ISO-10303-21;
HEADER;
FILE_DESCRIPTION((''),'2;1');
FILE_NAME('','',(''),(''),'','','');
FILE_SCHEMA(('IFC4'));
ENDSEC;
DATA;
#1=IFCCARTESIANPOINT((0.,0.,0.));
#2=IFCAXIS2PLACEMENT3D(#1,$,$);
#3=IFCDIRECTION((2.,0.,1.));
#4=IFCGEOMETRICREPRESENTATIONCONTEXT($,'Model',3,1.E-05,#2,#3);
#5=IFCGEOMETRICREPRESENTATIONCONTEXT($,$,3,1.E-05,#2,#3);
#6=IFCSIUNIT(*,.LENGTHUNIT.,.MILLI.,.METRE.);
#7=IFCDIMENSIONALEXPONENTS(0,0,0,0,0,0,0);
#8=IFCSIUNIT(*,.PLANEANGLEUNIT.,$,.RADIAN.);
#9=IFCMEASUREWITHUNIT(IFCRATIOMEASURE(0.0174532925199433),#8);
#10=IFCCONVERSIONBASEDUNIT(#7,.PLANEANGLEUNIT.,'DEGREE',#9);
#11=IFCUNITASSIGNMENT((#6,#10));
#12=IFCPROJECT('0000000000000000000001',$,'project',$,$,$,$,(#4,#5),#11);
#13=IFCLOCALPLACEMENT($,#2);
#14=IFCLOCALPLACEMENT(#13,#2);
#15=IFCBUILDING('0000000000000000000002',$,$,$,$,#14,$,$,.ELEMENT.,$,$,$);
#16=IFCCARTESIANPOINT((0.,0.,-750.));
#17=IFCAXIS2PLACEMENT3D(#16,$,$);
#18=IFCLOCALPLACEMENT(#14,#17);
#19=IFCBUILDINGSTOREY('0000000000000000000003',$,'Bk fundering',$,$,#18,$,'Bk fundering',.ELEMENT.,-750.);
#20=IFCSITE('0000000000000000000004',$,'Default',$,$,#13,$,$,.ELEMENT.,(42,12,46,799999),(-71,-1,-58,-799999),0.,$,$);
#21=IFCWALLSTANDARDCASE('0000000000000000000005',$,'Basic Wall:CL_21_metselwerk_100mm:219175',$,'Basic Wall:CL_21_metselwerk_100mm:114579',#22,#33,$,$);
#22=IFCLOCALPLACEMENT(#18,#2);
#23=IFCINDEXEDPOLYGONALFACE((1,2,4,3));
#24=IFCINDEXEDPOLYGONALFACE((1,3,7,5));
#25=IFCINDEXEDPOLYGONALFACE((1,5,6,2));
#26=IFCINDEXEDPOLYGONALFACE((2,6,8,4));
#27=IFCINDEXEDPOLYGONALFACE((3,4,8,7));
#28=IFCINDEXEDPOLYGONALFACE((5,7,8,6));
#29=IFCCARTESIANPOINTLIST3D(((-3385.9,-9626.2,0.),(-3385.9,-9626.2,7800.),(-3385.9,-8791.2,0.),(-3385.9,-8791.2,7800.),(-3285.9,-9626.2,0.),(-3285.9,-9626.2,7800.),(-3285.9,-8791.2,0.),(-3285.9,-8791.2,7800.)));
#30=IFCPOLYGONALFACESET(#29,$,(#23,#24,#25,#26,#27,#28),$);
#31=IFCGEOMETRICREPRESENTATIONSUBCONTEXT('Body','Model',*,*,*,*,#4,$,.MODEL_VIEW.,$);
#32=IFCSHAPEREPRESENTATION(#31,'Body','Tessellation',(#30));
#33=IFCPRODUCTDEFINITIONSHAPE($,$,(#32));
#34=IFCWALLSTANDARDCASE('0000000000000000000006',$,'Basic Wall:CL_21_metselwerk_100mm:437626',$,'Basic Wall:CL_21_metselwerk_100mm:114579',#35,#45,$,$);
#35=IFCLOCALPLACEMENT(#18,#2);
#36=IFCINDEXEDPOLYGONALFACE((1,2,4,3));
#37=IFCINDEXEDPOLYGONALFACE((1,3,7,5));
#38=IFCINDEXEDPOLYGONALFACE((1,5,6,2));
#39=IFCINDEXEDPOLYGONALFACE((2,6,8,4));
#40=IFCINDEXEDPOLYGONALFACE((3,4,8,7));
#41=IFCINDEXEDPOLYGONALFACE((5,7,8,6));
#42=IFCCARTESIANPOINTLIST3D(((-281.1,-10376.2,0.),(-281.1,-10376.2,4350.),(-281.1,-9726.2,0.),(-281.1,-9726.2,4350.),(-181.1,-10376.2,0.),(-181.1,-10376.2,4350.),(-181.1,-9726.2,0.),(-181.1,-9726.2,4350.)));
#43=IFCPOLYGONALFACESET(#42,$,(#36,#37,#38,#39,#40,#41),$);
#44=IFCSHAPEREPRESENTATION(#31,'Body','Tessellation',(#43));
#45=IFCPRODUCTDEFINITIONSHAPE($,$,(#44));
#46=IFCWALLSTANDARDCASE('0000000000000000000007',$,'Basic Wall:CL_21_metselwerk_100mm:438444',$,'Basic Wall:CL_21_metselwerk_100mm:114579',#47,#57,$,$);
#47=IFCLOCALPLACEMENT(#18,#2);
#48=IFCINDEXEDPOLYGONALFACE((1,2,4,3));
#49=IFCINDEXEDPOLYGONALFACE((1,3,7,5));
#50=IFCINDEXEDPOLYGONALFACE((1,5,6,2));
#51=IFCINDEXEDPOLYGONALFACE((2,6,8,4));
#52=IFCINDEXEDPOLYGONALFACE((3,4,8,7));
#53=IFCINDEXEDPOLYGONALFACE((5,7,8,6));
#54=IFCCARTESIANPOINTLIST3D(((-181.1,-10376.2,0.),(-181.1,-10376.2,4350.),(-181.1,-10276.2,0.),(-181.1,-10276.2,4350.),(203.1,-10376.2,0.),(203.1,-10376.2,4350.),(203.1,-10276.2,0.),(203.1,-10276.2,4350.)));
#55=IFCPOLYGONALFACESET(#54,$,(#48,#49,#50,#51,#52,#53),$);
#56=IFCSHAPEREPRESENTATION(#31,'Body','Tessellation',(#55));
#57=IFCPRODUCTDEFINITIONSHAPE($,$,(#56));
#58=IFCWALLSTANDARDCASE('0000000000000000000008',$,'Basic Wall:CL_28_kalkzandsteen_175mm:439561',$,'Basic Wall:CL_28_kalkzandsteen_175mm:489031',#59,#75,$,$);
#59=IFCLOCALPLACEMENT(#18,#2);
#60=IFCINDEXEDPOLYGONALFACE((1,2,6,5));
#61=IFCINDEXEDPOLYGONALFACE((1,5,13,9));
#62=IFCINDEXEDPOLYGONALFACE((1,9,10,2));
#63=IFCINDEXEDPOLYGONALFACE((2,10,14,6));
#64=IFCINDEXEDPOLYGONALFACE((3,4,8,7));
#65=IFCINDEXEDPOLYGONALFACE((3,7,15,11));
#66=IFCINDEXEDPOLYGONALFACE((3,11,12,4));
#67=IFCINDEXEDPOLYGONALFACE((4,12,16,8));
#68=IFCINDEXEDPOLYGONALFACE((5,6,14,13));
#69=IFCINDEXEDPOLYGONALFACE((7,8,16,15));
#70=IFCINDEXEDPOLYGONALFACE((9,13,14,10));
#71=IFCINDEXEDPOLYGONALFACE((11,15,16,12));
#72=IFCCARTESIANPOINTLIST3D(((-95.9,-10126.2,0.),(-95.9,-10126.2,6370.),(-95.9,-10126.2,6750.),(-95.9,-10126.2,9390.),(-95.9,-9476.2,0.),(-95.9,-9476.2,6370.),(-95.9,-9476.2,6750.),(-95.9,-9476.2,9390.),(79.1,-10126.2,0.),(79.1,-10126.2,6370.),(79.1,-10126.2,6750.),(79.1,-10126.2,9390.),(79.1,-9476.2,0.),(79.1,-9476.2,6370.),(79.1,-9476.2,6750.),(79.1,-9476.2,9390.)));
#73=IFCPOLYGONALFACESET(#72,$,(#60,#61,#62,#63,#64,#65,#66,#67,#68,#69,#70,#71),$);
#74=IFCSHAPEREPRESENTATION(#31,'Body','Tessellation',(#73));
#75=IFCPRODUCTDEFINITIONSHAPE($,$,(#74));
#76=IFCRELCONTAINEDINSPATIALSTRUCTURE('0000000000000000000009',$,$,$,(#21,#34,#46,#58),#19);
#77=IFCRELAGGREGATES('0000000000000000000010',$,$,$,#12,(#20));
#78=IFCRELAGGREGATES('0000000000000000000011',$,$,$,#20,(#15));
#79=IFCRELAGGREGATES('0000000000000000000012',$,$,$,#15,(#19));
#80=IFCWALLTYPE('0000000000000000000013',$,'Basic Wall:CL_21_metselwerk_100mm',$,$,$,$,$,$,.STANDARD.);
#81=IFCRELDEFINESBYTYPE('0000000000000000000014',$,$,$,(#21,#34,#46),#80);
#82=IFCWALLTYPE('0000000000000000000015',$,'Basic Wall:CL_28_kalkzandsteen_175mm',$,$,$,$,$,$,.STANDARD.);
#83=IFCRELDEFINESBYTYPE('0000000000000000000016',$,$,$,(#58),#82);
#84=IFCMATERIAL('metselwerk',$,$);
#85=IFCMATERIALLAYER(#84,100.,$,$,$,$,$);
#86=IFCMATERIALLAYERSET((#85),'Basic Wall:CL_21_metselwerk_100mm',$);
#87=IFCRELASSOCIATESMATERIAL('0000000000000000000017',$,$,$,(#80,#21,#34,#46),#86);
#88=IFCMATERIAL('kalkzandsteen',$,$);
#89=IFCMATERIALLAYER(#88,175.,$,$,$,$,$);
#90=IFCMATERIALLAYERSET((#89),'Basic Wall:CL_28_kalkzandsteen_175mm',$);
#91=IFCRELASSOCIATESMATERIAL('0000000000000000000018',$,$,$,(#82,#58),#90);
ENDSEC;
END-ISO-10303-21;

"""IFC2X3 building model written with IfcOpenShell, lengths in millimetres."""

from ifc_helpers import new_model, entity, si_unit, converted_unit, direction, frame, frame_2d, origin, place, context, subcontext, project, spatial, rectangle, extrude, material, layer, layer_set, layer_usage, type_object, element, save


model = new_model("IFC2X3")

# Units and contexts
model_context = context("Model", 3, precision=1e-05, world=origin(), true_north=direction((2.0, 0.0, 1.0)))
context_of_model = context(None, 3, precision=1e-05, world=origin(), true_north=direction((2.0, 0.0, 1.0)))
body_context = subcontext(model_context, "Body", "Model", "MODEL_VIEW")
ifc_project = project(units=[si_unit("LENGTHUNIT", "METRE", prefix="MILLI"), converted_unit("PLANEANGLEUNIT", "DEGREE", entity("IfcRatioMeasure", 0.0174532925199433), si_unit("PLANEANGLEUNIT", "RADIAN"), dimensions=[0, 0, 0, 0, 0, 0, 0])], contexts=[model_context, context_of_model])

# Site, building, storey
site_placement = place(None, origin())
site = spatial("IfcSite", under=ifc_project, at=site_placement, Name="Default", CompositionType="ELEMENT", RefLatitude=(42, 12, 46, 799999), RefLongitude=(-71, -1, -58, -799999), RefElevation=0.0)
building_placement = place(site_placement, origin())
building = spatial("IfcBuilding", under=site, at=building_placement, CompositionType="ELEMENT")
storey_placement = place(building_placement, frame((0.0, 0.0, -750.0)))
storey = spatial("IfcBuildingStorey", under=building, at=storey_placement, Name="Bk fundering", LongName="Bk fundering", CompositionType="ELEMENT", Elevation=-750.0)

# Shared definitions
ifc_material_1 = material(Name="kalkzandsteen")

# Walls
ifc_material_2 = material(Name="metselwerk")
ifc_layer_1 = layer(ifc_material_2, 100.0)
ifc_layer_set_1 = layer_set([ifc_layer_1], Name="Basic Wall:CL_21_metselwerk_100mm")
wall_type_1 = type_object("IfcWallType", Name="Basic Wall:CL_21_metselwerk_100mm", PredefinedType="STANDARD", material=ifc_layer_set_1)
ifc_layer_usage_1 = layer_usage(ifc_layer_set_1, "AXIS2", "NEGATIVE", 50.0)
wall_1_placement = place(storey_placement, frame((-3335.9, -8791.2, 0.0), z_axis=(0.0, 0.0, 1.0), x_axis=(0.0, -1.0, 0.0)))
element("IfcWallStandardCase", 1, at=wall_1_placement, inside=storey, type_object=wall_type_1, material=ifc_layer_usage_1, Name="Basic Wall:CL_21_metselwerk_100mm:219175", ObjectType="Basic Wall:CL_21_metselwerk_100mm:114579", context=body_context, shape_type="SweptSolid", body=[
    extrude(rectangle(XDim=835.0, YDim=100.0, at=frame_2d((417.5, 0.0), x_axis=(-1.0, 0.0))), origin(), (0.0, 0.0, 1.0), 7800.0),
])
ifc_layer_usage_2 = layer_usage(ifc_layer_set_1, "AXIS2", "NEGATIVE", 50.0)
wall_2_placement = place(storey_placement, frame((-231.1, -9726.2, 0.0), z_axis=(0.0, 0.0, 1.0), x_axis=(0.0, -1.0, 0.0)))
element("IfcWallStandardCase", 2, at=wall_2_placement, inside=storey, type_object=wall_type_1, material=ifc_layer_usage_2, Name="Basic Wall:CL_21_metselwerk_100mm:437626", ObjectType="Basic Wall:CL_21_metselwerk_100mm:114579", context=body_context, shape_type="SweptSolid", body=[
    extrude(rectangle(XDim=650.0, YDim=100.0, at=frame_2d((325.0, 0.0), x_axis=(-1.0, 0.0))), origin(), (0.0, 0.0, 1.0), 4350.0),
])
ifc_layer_usage_3 = layer_usage(ifc_layer_set_1, "AXIS2", "NEGATIVE", 50.0)
wall_3_placement = place(storey_placement, frame((-181.1, -10326.2, 0.0)))
element("IfcWallStandardCase", 3, at=wall_3_placement, inside=storey, type_object=wall_type_1, material=ifc_layer_usage_3, Name="Basic Wall:CL_21_metselwerk_100mm:438444", ObjectType="Basic Wall:CL_21_metselwerk_100mm:114579", context=body_context, shape_type="SweptSolid", body=[
    extrude(rectangle(XDim=384.2, YDim=100.0, at=frame_2d((192.1, 0.0), x_axis=(-1.0, 0.0))), origin(), (0.0, 0.0, 1.0), 4350.0),
])

# Wall, opening
ifc_layer_2 = layer(ifc_material_1, 175.0)
ifc_layer_set_2 = layer_set([ifc_layer_2], Name="Basic Wall:CL_28_kalkzandsteen_175mm")
ifc_layer_usage_4 = layer_usage(ifc_layer_set_2, "AXIS2", "NEGATIVE", 87.5)
wall_type_2 = type_object("IfcWallType", Name="Basic Wall:CL_28_kalkzandsteen_175mm", PredefinedType="STANDARD", material=ifc_layer_set_2)
wall_4_placement = place(storey_placement, frame((-8.4, -9476.2, 0.0), z_axis=(0.0, 0.0, 1.0), x_axis=(0.0, -1.0, 0.0)))
wall_4 = element("IfcWallStandardCase", 4, at=wall_4_placement, inside=storey, type_object=wall_type_2, material=ifc_layer_usage_4, Name="Basic Wall:CL_28_kalkzandsteen_175mm:439561", ObjectType="Basic Wall:CL_28_kalkzandsteen_175mm:489031", context=body_context, shape_type="SweptSolid", body=[
    extrude(rectangle(XDim=650.0, YDim=175.0, at=frame_2d((325.0, 0.0), x_axis=(-1.0, 0.0))), origin(), (0.0, 0.0, 1.0), 9390.0),
])
opening_1_placement = place(storey_placement, frame((-8.4, -9476.2, 0.0), z_axis=(0.0, 0.0, 1.0), x_axis=(0.0, -1.0, 0.0)))
element("IfcOpeningElement", 5, at=opening_1_placement, cuts=wall_4, ObjectType="Opening", context=body_context, shape_type="SweptSolid", body=[
    extrude(rectangle(XDim=650.0, YDim=175.0, at=frame_2d((0.0, 0.0), x_axis=(1.0, 0.0))), frame((325.0, 0.0, 6370.0)), (0.0, 0.0, 1.0), 380.0),
])

save(model, "model.ifc")
